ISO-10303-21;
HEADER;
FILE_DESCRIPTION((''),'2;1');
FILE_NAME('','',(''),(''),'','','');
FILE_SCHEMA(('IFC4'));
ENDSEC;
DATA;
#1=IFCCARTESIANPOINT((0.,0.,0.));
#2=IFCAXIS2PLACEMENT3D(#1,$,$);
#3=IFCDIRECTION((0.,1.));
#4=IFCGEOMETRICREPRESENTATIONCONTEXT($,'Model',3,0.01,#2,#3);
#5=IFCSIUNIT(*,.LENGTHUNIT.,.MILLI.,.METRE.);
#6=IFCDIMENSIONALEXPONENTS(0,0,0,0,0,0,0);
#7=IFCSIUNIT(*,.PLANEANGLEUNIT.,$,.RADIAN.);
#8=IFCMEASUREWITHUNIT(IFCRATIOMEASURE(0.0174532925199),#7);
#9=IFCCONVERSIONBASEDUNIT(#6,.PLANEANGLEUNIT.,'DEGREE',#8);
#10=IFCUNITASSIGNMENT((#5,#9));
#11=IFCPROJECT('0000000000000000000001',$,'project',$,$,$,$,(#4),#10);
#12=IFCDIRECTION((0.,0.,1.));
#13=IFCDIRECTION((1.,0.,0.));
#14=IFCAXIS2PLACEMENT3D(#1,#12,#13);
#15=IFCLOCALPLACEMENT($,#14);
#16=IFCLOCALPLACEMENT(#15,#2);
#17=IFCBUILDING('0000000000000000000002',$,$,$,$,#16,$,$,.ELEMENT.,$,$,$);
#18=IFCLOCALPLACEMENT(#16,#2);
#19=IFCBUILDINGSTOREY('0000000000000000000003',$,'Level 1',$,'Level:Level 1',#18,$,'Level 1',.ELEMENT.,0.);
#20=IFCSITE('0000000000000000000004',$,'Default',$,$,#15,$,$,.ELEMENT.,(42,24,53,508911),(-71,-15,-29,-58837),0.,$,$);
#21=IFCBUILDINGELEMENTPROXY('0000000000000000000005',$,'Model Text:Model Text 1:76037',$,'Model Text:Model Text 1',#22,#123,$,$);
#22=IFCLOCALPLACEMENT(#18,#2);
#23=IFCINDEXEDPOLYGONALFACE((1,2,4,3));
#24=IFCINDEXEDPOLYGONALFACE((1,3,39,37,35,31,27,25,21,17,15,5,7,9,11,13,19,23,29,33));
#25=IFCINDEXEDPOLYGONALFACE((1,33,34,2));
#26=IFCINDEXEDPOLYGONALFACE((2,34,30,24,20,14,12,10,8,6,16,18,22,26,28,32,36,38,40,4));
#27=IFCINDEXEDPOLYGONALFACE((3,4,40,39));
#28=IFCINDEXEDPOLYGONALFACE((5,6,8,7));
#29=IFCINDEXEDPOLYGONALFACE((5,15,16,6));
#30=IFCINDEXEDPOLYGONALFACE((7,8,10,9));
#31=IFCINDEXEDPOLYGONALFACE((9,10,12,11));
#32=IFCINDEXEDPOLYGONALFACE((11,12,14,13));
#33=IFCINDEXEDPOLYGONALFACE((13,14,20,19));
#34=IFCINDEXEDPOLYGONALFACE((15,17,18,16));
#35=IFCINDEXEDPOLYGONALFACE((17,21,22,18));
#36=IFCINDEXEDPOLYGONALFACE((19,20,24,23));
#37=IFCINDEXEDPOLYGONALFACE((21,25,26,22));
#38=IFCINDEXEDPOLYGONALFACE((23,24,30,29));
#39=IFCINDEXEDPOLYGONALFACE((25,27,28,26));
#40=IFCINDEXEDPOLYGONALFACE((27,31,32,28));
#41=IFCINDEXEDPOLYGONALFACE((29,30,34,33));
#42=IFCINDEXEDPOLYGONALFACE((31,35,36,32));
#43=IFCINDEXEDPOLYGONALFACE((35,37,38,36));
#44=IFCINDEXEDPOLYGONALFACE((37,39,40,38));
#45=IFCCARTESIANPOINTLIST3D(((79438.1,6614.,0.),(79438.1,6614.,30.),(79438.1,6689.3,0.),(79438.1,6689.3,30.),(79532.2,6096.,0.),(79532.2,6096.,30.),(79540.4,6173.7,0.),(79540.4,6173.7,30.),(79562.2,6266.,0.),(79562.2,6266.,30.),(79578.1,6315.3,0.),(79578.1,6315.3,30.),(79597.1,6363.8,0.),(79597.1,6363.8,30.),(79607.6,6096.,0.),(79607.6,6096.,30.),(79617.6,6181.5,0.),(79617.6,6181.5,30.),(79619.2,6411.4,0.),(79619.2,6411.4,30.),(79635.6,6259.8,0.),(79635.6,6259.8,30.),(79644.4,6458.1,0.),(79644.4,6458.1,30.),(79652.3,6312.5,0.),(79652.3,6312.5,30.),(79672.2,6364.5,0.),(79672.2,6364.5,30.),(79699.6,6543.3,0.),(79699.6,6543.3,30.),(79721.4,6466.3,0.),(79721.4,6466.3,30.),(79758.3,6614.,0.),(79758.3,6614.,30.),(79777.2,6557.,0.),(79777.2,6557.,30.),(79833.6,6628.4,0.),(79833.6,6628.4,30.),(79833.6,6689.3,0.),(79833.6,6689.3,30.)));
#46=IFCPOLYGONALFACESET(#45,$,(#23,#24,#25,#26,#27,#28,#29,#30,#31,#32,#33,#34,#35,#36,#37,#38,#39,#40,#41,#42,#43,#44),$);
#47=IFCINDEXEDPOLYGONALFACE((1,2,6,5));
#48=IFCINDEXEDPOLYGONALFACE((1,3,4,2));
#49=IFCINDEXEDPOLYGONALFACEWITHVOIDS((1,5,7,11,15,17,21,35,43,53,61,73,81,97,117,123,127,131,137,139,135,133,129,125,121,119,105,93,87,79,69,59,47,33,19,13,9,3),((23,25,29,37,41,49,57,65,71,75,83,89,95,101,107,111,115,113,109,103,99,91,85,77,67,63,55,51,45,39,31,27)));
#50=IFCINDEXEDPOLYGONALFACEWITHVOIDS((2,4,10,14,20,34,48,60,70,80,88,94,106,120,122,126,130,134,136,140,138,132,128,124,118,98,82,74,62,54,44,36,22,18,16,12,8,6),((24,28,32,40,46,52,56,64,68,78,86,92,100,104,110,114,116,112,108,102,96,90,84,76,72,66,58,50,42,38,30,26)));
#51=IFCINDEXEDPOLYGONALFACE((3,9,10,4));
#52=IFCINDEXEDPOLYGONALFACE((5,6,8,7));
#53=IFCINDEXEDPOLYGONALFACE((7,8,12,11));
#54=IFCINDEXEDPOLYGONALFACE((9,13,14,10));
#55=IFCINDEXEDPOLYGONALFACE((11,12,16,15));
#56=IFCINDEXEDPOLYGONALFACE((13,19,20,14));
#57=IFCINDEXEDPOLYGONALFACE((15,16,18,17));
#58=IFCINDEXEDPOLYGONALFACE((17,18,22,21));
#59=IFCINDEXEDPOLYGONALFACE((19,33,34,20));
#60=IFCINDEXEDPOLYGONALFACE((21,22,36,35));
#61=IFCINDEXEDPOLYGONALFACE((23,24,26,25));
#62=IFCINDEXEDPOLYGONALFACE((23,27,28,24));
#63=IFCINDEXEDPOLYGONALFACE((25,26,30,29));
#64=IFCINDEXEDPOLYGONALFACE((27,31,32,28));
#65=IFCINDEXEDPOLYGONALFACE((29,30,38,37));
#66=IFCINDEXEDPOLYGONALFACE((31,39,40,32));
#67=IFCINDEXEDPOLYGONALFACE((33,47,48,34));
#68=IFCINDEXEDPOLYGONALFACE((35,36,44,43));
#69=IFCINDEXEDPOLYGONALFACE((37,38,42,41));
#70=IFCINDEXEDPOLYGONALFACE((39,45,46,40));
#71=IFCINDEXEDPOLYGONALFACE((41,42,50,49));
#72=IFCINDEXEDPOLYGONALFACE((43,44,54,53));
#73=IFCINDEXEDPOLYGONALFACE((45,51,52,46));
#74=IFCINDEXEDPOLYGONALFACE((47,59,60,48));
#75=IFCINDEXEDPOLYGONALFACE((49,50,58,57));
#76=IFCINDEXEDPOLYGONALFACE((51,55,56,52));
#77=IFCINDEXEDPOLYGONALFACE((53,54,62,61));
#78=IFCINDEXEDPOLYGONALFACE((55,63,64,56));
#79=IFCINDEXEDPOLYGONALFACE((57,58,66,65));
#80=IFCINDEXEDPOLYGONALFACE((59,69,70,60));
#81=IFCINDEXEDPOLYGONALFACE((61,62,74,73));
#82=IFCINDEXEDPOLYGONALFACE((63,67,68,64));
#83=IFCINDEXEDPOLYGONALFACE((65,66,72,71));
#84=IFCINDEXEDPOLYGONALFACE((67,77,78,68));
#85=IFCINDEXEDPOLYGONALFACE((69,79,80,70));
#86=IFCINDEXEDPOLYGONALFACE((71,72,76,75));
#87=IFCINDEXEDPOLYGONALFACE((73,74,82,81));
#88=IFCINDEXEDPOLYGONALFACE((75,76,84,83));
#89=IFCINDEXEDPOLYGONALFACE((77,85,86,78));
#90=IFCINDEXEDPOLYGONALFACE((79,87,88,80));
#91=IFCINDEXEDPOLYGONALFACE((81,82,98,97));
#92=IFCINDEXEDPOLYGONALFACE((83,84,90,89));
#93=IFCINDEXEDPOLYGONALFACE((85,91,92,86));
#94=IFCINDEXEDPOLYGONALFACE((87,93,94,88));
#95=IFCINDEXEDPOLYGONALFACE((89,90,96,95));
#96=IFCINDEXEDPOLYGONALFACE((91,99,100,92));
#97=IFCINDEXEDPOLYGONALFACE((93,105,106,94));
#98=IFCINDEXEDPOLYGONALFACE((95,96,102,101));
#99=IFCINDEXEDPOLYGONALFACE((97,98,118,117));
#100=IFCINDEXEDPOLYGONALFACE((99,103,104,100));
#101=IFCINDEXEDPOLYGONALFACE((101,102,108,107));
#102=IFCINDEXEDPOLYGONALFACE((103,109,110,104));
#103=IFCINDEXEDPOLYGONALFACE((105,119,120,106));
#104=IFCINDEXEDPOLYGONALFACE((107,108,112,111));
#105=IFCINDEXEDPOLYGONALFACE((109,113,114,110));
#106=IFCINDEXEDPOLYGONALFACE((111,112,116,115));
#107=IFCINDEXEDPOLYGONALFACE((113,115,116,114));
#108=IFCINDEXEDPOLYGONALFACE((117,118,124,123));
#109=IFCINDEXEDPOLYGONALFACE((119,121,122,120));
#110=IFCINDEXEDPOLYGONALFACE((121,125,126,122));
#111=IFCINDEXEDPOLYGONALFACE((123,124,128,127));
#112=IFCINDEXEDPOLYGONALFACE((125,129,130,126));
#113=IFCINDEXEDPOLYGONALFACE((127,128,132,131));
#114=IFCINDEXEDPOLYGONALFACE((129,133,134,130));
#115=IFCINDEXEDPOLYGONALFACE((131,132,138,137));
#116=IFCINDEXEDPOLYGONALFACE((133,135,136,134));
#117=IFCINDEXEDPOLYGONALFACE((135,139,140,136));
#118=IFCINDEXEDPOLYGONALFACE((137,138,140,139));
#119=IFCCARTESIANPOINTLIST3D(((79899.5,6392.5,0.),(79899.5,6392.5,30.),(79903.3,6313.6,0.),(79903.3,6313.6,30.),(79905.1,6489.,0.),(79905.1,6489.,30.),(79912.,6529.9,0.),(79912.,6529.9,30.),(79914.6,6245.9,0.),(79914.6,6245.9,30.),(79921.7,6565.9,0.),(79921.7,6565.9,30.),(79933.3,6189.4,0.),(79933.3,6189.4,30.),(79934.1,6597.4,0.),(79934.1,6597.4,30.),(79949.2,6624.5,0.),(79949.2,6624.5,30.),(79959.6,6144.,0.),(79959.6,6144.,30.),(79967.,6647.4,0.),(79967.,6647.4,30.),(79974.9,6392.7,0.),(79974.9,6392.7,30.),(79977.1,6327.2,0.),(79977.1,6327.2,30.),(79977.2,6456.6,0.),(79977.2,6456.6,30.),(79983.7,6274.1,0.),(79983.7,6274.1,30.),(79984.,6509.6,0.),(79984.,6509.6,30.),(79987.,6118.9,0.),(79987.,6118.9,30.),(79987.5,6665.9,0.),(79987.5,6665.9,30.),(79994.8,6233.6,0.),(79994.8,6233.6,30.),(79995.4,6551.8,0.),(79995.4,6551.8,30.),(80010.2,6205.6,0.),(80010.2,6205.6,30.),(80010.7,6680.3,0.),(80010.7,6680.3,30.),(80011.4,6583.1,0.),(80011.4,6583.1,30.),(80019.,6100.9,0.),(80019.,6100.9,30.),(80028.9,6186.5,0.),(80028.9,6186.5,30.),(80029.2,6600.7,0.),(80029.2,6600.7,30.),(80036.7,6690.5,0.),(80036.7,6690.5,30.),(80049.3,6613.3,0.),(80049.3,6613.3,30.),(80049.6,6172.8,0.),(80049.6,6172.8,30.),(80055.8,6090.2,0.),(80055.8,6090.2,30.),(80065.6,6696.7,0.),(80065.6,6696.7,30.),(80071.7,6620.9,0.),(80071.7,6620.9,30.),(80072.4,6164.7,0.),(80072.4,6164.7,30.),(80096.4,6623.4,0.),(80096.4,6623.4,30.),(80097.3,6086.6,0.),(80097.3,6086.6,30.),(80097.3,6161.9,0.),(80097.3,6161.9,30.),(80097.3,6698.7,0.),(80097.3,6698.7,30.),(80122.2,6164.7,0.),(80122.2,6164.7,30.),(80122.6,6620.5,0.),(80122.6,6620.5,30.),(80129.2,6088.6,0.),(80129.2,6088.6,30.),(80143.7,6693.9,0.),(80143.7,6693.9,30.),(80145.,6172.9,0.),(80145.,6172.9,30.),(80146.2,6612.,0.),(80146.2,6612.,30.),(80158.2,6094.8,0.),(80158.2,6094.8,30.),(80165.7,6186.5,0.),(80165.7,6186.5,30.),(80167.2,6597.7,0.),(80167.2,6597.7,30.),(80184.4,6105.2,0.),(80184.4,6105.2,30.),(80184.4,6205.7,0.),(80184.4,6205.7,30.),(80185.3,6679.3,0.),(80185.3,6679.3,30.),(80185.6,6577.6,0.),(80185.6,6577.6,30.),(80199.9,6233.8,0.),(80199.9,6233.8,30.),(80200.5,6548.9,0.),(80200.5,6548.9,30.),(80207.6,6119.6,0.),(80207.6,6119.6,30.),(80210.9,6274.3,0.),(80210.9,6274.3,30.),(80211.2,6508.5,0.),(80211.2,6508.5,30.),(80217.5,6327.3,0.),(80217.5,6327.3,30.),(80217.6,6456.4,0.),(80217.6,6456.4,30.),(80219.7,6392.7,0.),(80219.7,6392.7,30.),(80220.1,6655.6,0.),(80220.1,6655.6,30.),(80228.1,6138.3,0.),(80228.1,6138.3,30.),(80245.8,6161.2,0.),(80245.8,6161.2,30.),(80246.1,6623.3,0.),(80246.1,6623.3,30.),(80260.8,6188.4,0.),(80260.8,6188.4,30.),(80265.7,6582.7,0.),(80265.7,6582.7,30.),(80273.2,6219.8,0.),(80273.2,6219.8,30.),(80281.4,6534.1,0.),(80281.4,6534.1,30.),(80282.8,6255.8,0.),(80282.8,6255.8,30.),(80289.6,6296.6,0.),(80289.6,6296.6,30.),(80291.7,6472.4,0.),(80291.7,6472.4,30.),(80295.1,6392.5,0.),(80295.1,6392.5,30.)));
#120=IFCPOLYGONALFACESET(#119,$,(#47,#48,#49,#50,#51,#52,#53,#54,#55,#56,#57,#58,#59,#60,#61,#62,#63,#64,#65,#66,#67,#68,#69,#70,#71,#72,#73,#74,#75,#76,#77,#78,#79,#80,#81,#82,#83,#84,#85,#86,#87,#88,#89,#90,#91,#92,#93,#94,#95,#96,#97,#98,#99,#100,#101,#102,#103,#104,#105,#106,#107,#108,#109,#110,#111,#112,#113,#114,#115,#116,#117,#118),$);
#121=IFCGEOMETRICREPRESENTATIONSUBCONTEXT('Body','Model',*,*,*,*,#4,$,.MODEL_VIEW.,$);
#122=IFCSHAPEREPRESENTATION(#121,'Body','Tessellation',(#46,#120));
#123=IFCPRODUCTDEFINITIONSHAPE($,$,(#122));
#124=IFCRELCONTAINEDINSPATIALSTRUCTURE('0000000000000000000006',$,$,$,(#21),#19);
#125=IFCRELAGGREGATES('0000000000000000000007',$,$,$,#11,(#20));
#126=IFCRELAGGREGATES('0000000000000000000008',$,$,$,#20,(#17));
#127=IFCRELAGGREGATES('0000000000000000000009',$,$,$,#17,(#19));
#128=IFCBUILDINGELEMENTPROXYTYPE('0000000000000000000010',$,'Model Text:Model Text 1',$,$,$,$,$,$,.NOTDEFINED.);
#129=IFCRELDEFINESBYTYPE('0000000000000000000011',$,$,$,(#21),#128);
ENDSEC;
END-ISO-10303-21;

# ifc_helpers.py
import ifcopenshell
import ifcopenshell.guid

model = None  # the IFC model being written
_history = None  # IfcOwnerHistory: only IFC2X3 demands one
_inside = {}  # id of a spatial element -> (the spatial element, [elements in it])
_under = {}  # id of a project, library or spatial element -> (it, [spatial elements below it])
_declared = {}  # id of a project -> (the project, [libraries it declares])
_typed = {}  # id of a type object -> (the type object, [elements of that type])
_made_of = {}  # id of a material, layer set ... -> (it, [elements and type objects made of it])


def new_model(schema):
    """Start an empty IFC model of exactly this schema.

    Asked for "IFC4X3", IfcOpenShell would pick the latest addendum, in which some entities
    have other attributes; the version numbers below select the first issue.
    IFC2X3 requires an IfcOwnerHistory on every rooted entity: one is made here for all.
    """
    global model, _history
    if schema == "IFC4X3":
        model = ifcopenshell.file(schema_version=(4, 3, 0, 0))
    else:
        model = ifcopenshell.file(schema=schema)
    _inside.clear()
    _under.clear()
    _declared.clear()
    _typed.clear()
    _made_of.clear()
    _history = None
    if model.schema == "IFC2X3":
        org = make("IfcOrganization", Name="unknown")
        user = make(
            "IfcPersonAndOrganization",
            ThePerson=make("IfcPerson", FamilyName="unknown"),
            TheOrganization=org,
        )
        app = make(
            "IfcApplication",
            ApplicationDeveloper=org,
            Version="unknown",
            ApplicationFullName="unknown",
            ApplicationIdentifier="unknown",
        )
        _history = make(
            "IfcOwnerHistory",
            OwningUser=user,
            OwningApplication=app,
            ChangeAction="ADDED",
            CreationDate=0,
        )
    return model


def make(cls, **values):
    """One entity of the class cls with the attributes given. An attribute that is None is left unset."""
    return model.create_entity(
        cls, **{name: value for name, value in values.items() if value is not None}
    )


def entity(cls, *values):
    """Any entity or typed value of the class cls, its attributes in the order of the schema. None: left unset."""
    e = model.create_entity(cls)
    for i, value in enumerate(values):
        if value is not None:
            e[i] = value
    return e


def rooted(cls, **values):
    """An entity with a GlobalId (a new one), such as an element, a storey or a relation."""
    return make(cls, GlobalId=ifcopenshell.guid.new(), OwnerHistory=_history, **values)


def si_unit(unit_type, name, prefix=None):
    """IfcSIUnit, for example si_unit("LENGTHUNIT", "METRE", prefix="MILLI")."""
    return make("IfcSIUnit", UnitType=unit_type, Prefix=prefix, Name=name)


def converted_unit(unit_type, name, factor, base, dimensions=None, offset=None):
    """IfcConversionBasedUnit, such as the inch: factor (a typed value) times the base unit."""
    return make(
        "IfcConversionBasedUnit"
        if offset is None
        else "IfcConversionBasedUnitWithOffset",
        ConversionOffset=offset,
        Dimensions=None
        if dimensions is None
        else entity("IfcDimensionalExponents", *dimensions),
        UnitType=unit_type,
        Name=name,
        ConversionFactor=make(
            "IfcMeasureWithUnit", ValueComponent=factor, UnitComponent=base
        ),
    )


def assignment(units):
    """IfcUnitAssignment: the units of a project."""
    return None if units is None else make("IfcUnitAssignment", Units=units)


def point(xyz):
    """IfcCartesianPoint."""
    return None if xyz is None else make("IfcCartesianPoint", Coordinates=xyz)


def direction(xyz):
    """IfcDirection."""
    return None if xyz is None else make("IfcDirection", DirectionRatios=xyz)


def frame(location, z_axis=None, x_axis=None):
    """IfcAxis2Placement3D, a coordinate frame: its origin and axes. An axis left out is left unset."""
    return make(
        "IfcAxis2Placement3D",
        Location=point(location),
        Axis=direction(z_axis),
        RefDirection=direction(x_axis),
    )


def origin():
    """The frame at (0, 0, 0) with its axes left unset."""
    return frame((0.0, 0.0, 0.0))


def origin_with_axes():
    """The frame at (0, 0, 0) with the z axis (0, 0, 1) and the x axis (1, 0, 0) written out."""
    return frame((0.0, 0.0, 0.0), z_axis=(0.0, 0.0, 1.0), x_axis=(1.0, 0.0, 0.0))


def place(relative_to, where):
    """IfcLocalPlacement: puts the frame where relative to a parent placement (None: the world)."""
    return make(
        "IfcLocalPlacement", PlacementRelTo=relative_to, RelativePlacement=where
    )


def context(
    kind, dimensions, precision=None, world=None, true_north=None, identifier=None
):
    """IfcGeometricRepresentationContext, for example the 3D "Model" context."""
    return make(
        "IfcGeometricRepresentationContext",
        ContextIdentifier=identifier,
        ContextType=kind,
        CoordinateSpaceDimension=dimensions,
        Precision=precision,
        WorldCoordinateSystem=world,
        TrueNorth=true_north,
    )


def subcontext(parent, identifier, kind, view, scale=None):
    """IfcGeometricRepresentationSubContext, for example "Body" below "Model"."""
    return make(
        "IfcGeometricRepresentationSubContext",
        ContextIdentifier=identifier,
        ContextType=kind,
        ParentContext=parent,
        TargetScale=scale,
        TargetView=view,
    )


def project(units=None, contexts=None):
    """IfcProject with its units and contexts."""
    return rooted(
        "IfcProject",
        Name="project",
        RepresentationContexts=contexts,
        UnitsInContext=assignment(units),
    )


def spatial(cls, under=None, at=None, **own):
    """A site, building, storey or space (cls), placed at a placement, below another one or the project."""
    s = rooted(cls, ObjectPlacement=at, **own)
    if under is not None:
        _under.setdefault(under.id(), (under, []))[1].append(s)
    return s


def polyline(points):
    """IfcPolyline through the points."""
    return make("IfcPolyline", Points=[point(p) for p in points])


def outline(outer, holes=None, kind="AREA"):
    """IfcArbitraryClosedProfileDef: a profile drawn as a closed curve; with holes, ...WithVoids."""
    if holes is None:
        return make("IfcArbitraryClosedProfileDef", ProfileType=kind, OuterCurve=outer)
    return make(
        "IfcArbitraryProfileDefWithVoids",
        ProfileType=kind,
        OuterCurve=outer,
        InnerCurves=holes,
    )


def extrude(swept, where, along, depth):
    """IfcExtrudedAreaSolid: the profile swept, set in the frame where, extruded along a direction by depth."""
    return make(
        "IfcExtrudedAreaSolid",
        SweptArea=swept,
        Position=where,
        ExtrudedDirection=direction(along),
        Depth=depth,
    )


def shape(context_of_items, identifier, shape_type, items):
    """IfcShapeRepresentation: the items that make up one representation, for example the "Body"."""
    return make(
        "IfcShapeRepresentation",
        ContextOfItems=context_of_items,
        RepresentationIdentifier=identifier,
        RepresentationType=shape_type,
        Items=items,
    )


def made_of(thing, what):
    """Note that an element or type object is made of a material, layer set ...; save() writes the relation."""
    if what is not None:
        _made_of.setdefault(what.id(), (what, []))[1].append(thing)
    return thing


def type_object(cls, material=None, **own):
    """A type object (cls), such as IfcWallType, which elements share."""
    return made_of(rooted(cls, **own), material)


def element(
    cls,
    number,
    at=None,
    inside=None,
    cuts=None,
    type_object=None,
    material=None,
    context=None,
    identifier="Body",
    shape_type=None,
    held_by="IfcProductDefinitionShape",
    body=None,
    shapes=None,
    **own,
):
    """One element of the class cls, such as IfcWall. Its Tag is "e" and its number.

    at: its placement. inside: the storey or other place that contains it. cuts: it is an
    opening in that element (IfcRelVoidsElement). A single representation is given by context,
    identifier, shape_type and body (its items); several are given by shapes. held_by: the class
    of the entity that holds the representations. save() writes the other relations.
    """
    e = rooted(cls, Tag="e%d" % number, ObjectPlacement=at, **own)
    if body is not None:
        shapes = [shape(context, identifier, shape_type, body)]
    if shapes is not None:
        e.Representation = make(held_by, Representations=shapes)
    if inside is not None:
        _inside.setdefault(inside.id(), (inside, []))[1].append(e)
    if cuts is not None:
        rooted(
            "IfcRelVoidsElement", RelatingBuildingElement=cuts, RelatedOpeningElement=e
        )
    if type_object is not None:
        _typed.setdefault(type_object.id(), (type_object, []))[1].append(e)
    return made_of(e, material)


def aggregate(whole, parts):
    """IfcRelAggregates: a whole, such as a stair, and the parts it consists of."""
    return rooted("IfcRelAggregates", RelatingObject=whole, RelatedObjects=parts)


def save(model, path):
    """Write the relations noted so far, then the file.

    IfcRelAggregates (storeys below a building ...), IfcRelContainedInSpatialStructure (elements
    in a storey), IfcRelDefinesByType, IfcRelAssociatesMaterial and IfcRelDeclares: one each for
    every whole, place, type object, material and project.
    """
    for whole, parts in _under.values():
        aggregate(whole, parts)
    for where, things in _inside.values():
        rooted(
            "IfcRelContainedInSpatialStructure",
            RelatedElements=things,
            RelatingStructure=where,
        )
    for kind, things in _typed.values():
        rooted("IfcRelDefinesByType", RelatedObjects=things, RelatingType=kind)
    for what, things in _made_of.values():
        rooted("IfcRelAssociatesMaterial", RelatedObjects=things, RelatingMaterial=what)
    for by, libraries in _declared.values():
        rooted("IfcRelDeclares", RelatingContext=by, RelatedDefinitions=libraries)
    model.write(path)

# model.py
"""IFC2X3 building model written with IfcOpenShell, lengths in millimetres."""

from ifc_helpers import new_model, entity, si_unit, converted_unit, direction, frame, origin, origin_with_axes, place, context, subcontext, project, spatial, polyline, outline, extrude, type_object, element, save


model = new_model("IFC2X3")

# Units and contexts
model_context = context("Model", 3, precision=0.01, world=origin(), true_north=direction((0.0, 1.0)))
body_context = subcontext(model_context, "Body", "Model", "MODEL_VIEW")
ifc_project = project(units=[si_unit("LENGTHUNIT", "METRE", prefix="MILLI"), converted_unit("PLANEANGLEUNIT", "DEGREE", entity("IfcRatioMeasure", 0.0174532925199), si_unit("PLANEANGLEUNIT", "RADIAN"), dimensions=[0, 0, 0, 0, 0, 0, 0])], contexts=[model_context])

# Site, building, storey
site_placement = place(None, origin_with_axes())
site = spatial("IfcSite", under=ifc_project, at=site_placement, Name="Default", CompositionType="ELEMENT", RefLatitude=(42, 24, 53, 508911), RefLongitude=(-71, -15, -29, -58837), RefElevation=0.0)
building_placement = place(site_placement, origin())
building = spatial("IfcBuilding", under=site, at=building_placement, CompositionType="ELEMENT")
storey_placement = place(building_placement, origin())
storey = spatial("IfcBuildingStorey", under=building, at=storey_placement, Name="Level 1", ObjectType="Level:Level 1", LongName="Level 1", CompositionType="ELEMENT", Elevation=0.0)

# Building element proxy
building_element_proxy_type_1 = type_object("IfcBuildingElementProxyType", Name="Model Text:Model Text 1", PredefinedType="NOTDEFINED")
proxy_1_placement = place(storey_placement, frame((79438.1, 6086.6, 0.0)))
element("IfcBuildingElementProxy", 1, at=proxy_1_placement, inside=storey, type_object=building_element_proxy_type_1, Name="Model Text:Model Text 1:76037", ObjectType="Model Text:Model Text 1", context=body_context, shape_type="SweptSolid", body=[
    extrude(outline(polyline([(-199.9, -209.0), (-199.9, -284.3), (195.7, -284.3), (195.7, -223.4), (139.3, -152.0), (83.5, -61.3), (34.2, 40.5), (14.4, 92.5), (-2.4, 145.2), (-20.3, 223.5), (-30.3, 309.0), (-105.7, 309.0), (-97.5, 231.3), (-75.7, 139.0), (-59.9, 89.7), (-40.9, 41.2), (-18.8, -6.4), (6.4, -53.1), (61.7, -138.3), (120.3, -209.0), (-199.9, -209.0)])), frame((199.9, 318.4, 0.0), z_axis=(0.0, 0.0, -1.0), x_axis=(1.0, 0.0, 0.0)), (0.0, 0.0, -1.0), 30.0),
    extrude(outline(polyline([(-10.6, -198.7), (68.3, -198.7), (136.5, -190.7), (193.9, -174.7), (240.5, -150.6), (266.9, -124.4), (286.3, -93.2), (298.8, -57.0), (304.3, -15.7), (303.8, 16.2), (299.0, 45.5), (289.9, 72.1), (276.6, 96.0), (258.9, 117.3), (236.9, 136.2), (210.4, 152.5), (179.6, 166.3), (144.1, 177.6), (103.7, 186.3), (8.2, 196.4), (-71.8, 196.7), (-134.0, 189.4), (-183.3, 176.1), (-224.7, 158.4), (-258.2, 133.9), (-283.5, 100.3), (-300.1, 59.5), (-307.1, 13.4), (-306.6, -18.4), (-301.8, -47.5), (-292.8, -74.0), (-279.6, -97.9), (-262.0, -119.2), (-240.0, -138.1), (-213.6, -154.5), (-182.8, -168.4), (-147.3, -179.8), (-106.7, -188.6), (-10.6, -198.7)]), holes=[polyline([(-7.2, -123.5), (-71.0, -118.2), (-123.6, -108.8), (-165.2, -95.4), (-195.7, -78.0), (-212.4, -59.4), (-224.1, -38.7), (-230.6, -15.9), (-231.9, 8.9), (-227.8, 35.0), (-218.1, 58.1), (-202.8, 78.4), (-182.0, 95.8), (-152.6, 109.4), (-111.7, 118.1), (-59.4, 122.0), (4.4, 121.1), (69.6, 115.8), (122.2, 106.7), (162.2, 93.7), (189.5, 77.0), (207.7, 57.4), (220.4, 36.0), (227.5, 12.8), (229.1, -12.1), (225.2, -36.8), (215.9, -59.2), (201.3, -79.3), (181.4, -97.1), (152.6, -111.2), (111.6, -120.3), (58.3, -124.4), (-7.2, -123.5)])]), frame((660.5, 304.7, 0.0), z_axis=(0.0, 0.0, 1.0), x_axis=(0.047515, -0.998871, 0.0)), (0.0, 0.0, 1.0), 30.0),
])

save(model, "model.ifc")
